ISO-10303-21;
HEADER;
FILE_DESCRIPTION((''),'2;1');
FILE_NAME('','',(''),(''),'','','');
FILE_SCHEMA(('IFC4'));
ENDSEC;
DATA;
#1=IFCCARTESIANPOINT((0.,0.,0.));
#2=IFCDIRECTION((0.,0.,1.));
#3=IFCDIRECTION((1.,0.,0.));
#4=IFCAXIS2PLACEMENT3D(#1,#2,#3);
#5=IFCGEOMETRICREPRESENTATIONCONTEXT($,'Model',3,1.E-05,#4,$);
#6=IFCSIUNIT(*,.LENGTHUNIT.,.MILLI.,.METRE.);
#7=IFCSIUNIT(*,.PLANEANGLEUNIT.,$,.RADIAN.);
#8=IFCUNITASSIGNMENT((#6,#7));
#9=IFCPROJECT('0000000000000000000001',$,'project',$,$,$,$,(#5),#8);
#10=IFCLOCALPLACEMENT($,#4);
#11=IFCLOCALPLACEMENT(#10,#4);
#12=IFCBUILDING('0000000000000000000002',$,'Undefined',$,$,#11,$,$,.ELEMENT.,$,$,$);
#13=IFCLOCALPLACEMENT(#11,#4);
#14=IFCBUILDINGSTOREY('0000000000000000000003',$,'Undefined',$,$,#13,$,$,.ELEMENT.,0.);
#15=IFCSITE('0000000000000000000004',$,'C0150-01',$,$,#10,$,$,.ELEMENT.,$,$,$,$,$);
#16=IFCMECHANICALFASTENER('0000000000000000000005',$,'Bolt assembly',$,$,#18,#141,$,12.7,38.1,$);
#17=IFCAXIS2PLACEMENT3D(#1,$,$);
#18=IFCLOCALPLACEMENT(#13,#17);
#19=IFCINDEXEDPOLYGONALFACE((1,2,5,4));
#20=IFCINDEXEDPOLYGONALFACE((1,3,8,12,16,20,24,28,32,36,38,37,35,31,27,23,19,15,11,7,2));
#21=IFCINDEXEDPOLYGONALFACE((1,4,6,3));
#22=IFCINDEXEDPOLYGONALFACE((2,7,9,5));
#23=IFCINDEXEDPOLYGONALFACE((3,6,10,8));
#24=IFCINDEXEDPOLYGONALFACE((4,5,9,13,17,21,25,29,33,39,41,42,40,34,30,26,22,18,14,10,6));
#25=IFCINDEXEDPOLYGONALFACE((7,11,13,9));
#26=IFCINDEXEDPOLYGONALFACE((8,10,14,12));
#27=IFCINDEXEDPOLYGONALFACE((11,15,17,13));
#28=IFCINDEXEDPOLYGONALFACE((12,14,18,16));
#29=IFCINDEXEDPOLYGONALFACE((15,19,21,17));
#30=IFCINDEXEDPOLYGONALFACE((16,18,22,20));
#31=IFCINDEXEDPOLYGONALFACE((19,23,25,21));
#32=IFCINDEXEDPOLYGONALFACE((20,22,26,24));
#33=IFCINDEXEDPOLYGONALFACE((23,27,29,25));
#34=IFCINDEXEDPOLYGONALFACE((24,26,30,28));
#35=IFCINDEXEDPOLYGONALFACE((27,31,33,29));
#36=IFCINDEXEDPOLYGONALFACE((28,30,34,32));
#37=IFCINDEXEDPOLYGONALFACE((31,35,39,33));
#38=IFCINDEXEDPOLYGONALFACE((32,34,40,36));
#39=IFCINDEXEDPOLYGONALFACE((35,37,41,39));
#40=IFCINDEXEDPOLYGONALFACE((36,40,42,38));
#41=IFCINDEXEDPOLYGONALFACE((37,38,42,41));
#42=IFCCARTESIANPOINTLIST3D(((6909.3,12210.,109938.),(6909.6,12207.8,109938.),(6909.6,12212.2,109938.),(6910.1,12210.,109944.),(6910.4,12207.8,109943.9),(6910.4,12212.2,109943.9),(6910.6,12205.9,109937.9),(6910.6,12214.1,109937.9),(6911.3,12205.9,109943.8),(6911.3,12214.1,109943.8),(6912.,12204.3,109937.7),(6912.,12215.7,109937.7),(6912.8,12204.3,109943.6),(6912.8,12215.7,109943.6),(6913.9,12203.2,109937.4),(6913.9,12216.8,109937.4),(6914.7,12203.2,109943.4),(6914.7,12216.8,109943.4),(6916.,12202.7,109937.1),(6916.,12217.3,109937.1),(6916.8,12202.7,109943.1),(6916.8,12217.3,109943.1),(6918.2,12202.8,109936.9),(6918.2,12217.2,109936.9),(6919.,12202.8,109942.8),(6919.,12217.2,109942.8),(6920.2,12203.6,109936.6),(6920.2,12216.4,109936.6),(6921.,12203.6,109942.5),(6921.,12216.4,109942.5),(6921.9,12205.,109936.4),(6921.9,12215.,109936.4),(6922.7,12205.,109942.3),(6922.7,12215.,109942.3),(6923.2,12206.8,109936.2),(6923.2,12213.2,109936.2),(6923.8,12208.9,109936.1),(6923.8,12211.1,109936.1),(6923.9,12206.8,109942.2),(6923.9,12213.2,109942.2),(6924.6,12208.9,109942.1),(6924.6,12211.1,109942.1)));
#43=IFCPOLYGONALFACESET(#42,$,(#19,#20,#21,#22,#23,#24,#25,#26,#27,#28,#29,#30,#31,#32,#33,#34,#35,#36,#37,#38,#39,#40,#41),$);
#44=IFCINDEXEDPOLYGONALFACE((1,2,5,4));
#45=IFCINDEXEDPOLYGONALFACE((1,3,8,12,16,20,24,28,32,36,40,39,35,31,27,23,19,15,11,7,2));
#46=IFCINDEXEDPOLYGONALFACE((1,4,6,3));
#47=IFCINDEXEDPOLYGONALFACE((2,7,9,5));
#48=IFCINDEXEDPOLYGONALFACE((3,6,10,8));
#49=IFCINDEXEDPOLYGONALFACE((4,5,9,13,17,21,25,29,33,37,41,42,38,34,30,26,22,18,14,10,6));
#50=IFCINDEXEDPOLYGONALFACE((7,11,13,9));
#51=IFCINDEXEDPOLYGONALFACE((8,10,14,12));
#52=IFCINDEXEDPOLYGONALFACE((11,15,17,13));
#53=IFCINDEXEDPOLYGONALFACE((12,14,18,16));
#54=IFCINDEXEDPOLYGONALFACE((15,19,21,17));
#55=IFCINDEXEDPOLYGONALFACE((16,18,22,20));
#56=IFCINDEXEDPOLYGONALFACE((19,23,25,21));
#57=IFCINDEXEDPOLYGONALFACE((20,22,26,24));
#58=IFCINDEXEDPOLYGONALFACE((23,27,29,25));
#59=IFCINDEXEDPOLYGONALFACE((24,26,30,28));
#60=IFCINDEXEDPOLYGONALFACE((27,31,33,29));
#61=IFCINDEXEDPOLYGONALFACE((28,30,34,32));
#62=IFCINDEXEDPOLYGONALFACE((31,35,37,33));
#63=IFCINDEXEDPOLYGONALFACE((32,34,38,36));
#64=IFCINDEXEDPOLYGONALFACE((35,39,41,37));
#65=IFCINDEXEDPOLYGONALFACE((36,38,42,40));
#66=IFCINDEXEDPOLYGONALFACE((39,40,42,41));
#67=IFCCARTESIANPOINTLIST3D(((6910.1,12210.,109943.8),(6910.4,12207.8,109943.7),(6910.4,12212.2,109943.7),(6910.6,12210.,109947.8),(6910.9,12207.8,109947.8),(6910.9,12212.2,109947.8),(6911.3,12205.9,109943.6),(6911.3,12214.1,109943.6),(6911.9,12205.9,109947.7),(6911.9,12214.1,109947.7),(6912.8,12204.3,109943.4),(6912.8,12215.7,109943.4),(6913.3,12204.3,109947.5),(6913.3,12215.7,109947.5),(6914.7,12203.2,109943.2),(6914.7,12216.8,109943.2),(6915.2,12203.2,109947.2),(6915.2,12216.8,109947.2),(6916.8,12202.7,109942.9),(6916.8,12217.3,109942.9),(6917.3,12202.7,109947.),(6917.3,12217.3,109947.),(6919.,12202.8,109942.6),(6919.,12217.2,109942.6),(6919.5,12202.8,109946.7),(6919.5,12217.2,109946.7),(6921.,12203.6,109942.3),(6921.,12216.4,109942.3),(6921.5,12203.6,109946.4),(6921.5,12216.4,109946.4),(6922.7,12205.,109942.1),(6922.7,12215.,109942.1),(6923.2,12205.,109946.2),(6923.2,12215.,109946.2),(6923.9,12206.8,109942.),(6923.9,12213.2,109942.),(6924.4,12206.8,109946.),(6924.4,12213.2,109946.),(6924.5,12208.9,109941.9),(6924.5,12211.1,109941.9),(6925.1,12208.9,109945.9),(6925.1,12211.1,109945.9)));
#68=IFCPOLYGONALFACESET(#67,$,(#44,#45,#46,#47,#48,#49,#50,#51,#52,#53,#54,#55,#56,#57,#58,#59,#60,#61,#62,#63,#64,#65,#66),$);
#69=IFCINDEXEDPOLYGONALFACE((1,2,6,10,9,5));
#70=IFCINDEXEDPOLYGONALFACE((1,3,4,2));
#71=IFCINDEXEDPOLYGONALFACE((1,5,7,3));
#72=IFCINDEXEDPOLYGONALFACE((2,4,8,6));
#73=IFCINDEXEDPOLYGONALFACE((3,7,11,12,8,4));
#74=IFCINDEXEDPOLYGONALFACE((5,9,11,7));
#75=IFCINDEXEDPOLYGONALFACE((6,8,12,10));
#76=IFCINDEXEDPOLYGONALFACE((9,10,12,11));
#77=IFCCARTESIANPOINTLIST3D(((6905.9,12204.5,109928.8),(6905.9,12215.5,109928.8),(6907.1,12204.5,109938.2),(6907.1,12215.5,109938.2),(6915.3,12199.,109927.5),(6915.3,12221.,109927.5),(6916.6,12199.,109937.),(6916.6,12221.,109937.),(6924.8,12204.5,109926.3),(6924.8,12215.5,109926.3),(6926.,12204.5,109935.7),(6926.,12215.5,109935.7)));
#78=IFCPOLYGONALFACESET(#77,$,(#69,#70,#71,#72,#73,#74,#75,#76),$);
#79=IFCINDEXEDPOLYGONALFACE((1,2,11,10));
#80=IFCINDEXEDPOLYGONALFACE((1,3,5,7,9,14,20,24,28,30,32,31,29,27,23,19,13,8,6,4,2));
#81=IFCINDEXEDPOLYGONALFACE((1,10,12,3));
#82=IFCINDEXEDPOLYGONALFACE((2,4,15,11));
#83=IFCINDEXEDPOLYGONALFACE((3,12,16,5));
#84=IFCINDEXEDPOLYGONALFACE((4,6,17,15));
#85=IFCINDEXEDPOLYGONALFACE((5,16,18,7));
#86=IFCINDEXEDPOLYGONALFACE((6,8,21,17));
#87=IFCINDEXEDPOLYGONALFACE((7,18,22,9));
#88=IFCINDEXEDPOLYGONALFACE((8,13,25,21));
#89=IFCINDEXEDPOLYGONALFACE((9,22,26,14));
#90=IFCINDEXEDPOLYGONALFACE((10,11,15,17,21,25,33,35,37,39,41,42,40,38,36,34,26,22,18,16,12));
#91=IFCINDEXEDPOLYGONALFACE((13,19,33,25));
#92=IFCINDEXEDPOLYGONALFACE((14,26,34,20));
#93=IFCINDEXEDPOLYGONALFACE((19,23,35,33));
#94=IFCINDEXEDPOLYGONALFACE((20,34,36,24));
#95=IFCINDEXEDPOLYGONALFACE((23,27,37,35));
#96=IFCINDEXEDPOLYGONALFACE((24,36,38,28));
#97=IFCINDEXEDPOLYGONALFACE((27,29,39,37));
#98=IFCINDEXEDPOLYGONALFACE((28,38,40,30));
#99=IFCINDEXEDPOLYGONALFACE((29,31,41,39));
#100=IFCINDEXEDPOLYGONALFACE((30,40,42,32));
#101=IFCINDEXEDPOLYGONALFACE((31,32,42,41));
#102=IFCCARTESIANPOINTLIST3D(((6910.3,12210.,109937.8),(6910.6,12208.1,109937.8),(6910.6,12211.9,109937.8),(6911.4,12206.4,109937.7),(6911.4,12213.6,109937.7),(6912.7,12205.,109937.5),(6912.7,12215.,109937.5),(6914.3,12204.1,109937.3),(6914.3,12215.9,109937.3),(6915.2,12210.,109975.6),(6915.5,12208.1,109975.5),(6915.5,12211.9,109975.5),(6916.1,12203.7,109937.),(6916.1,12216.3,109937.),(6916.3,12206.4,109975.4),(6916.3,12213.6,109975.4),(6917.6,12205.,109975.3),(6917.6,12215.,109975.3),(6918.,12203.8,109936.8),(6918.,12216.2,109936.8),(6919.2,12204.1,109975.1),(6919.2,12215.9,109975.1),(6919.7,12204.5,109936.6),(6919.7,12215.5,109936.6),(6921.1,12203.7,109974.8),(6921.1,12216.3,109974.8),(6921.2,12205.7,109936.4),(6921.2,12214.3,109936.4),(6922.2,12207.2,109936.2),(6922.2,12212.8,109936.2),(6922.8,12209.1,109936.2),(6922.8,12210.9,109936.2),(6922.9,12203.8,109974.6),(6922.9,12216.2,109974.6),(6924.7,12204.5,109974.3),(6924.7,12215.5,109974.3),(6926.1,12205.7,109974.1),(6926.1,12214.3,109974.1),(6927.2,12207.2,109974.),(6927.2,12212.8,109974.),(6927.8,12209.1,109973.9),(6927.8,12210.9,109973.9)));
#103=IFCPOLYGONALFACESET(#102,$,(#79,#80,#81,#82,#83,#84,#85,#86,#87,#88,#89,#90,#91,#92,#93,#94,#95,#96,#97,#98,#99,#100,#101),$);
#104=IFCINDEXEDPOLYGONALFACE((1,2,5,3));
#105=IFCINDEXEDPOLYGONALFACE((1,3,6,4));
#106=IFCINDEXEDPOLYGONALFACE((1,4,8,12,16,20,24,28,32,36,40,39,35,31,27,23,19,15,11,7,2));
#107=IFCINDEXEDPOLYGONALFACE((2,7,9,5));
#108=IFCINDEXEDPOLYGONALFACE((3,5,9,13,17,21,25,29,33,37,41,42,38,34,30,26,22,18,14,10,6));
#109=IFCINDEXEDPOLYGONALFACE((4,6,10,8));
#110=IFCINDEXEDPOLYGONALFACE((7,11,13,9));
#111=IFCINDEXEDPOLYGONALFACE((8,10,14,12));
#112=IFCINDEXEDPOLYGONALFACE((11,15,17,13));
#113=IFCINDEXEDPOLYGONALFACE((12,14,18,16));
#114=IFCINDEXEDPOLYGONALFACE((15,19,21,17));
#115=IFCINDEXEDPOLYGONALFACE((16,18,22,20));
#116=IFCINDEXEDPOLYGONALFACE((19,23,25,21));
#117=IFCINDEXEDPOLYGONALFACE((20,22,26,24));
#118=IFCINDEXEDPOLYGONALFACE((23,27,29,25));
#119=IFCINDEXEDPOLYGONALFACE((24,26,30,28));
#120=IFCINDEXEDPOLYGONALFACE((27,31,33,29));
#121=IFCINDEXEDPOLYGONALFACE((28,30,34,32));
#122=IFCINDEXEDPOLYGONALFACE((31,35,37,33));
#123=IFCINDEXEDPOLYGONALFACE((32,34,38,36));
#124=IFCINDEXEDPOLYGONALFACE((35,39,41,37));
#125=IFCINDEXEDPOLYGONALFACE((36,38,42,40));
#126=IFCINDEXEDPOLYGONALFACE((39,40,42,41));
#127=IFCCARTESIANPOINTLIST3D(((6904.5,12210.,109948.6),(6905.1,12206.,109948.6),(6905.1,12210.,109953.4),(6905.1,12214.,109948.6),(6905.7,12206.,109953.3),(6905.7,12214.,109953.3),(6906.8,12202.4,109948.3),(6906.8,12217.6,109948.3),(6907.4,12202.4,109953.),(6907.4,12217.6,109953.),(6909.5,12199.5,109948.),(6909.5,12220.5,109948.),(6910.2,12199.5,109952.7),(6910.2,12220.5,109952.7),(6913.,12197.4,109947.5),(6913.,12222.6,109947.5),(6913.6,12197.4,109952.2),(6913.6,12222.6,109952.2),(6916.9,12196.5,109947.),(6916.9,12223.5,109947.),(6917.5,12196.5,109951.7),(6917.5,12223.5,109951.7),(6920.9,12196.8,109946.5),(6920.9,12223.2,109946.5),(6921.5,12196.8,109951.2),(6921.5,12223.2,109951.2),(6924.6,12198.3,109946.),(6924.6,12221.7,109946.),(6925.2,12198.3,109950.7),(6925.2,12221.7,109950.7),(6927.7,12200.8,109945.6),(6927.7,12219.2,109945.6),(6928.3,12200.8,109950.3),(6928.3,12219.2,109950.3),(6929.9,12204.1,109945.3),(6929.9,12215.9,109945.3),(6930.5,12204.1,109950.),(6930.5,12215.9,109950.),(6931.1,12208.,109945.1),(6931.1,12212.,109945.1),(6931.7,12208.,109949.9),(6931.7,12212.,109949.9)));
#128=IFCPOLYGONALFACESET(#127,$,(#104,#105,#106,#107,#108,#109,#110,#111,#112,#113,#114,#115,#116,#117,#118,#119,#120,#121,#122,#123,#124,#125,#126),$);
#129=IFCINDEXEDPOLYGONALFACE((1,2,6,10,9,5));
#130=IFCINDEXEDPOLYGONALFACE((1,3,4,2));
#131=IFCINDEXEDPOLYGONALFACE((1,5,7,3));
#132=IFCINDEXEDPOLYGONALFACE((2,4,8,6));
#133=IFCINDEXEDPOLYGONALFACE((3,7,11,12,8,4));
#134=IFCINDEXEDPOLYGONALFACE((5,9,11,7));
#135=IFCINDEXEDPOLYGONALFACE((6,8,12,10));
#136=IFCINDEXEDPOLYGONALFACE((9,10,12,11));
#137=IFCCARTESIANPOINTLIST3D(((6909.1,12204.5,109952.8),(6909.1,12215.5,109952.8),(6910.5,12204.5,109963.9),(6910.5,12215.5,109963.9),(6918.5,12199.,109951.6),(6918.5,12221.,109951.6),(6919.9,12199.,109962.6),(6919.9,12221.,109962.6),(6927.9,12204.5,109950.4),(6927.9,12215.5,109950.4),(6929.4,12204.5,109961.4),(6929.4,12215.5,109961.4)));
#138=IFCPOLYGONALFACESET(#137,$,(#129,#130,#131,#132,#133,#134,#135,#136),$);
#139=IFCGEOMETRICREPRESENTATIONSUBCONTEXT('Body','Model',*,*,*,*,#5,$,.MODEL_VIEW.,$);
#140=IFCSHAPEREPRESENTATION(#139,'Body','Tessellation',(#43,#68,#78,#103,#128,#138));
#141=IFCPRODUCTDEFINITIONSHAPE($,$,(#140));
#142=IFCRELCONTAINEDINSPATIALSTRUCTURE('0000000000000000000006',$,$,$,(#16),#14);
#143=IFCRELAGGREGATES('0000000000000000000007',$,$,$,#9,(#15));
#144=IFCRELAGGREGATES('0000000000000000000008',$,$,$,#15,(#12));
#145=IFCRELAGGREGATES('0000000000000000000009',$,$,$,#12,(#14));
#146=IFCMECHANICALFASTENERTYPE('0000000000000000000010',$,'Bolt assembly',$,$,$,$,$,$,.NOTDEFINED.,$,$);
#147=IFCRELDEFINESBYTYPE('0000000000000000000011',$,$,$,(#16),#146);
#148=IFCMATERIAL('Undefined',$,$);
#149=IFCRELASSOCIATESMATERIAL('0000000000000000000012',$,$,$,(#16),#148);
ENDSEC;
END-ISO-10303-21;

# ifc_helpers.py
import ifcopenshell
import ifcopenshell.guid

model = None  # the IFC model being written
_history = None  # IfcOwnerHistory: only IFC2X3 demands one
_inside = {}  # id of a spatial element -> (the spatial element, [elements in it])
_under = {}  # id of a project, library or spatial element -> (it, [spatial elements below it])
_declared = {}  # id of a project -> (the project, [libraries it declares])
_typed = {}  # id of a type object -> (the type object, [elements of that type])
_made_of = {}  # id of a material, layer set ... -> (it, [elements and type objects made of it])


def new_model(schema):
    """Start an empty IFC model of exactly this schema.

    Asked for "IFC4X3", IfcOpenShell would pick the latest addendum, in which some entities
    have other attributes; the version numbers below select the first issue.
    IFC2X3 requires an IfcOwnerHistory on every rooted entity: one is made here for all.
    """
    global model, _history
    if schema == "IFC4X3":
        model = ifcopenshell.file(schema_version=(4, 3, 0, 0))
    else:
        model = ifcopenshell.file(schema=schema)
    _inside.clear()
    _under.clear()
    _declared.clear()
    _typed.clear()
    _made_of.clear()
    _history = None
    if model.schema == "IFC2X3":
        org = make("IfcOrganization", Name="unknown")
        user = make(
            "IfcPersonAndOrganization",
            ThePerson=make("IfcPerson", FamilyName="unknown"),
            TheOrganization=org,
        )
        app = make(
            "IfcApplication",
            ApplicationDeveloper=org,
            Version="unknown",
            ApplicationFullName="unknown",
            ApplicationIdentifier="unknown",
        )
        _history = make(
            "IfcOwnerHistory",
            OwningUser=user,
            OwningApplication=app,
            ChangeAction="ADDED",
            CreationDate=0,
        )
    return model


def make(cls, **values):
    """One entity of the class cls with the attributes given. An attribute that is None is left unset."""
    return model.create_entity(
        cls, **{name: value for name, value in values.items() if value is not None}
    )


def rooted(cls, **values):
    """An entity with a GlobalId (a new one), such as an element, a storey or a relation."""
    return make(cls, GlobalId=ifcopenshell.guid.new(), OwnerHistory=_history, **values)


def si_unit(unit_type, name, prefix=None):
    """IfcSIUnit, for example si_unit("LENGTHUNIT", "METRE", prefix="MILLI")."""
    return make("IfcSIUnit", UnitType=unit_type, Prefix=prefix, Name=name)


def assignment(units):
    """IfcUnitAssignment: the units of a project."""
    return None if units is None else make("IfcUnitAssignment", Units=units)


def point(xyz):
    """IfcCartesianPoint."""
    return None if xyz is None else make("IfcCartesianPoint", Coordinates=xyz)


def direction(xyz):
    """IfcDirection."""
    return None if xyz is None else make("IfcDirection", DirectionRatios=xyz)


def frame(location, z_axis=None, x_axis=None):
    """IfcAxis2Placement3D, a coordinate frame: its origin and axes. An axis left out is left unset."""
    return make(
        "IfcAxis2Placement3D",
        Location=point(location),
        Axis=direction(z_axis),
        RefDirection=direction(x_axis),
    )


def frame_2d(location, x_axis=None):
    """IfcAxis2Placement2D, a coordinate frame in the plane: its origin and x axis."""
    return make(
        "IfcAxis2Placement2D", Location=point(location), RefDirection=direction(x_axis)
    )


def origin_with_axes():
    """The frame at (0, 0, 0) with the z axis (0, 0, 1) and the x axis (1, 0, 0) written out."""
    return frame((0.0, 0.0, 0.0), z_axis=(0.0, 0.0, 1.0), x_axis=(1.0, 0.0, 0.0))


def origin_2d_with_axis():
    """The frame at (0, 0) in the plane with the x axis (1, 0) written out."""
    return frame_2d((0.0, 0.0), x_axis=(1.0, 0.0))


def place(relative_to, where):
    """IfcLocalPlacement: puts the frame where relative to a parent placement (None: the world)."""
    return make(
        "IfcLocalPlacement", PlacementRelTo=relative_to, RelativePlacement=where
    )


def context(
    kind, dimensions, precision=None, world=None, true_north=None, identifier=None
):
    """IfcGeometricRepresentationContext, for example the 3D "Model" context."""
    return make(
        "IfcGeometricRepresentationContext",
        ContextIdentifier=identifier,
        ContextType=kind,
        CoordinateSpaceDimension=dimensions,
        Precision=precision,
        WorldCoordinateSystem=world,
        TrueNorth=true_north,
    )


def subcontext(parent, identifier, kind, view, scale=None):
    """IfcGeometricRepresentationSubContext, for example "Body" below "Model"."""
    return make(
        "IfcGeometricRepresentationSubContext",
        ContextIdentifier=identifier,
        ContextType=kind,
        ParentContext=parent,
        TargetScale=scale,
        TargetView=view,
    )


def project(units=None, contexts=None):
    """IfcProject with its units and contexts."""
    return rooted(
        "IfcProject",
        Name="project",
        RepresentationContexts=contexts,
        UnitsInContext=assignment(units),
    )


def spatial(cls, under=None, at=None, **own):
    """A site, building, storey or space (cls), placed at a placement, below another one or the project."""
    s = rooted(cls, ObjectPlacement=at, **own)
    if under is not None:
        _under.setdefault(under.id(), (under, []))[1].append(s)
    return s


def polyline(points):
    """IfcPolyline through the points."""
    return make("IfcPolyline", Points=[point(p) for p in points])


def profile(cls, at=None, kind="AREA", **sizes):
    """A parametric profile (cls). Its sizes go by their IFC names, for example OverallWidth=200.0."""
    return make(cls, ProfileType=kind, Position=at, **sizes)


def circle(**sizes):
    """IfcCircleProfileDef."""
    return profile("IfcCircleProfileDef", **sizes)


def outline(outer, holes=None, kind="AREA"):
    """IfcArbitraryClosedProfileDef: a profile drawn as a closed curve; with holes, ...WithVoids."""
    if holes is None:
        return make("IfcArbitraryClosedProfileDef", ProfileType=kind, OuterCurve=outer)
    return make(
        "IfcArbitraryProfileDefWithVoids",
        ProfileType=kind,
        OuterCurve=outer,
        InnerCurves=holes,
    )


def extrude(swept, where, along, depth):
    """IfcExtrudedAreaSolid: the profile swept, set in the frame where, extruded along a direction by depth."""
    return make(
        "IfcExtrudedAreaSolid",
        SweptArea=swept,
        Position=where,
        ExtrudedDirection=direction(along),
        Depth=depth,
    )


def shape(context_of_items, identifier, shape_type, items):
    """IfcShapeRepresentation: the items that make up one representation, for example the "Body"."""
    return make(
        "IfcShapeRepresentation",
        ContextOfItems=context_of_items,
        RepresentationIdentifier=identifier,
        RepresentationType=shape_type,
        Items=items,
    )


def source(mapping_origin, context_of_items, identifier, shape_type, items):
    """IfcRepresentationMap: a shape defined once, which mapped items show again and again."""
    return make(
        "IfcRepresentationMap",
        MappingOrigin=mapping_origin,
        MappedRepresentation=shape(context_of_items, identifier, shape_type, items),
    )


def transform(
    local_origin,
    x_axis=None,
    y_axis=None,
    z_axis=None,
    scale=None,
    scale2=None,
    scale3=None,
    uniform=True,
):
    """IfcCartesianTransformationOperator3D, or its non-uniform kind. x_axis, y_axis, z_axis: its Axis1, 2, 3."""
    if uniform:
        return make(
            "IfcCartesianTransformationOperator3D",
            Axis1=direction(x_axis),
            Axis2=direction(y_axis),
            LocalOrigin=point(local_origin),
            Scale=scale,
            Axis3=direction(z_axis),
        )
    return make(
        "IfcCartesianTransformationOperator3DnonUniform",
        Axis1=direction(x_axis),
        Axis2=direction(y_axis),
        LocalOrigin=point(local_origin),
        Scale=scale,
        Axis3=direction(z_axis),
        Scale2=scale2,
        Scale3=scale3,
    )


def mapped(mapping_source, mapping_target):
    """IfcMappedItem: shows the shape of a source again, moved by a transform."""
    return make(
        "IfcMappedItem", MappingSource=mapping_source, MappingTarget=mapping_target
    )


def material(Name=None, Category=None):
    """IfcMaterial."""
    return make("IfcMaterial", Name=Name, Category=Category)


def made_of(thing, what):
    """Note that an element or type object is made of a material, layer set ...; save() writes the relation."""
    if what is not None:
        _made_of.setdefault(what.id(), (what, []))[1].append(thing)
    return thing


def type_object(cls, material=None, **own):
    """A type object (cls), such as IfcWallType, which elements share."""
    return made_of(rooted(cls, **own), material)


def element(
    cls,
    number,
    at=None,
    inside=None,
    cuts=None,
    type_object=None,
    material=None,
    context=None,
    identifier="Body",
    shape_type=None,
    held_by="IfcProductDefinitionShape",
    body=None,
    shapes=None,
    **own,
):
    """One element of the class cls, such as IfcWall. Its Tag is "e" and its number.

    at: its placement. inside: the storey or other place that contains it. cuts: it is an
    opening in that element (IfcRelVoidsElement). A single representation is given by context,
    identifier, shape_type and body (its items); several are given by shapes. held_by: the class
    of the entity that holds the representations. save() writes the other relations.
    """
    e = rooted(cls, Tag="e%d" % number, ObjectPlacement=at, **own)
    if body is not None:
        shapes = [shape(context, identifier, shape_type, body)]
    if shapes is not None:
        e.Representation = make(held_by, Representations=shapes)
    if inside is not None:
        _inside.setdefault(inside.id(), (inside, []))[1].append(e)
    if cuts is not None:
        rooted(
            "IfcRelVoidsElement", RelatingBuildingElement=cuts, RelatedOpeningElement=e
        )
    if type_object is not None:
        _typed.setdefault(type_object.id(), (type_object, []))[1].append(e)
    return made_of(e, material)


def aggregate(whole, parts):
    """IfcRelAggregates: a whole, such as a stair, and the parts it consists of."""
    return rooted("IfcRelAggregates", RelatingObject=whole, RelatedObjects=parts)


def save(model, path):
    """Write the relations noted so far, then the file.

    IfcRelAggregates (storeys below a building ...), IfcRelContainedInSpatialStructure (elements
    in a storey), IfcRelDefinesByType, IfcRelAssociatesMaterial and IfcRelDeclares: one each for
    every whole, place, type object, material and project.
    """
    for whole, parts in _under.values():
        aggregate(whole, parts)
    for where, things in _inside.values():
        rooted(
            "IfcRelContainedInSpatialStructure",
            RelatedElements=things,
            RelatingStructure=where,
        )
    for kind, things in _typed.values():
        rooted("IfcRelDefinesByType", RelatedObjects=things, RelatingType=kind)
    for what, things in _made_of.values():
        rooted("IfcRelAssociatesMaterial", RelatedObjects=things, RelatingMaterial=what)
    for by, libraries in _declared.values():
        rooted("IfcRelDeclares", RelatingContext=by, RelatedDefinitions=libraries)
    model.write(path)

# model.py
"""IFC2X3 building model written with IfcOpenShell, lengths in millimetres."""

from ifc_helpers import new_model, si_unit, frame, origin_with_axes, origin_2d_with_axis, place, context, subcontext, project, spatial, polyline, circle, outline, extrude, source, transform, mapped, material, type_object, element, save


model = new_model("IFC2X3")

# Units and contexts
model_context = context("Model", 3, precision=1e-05, world=origin_with_axes())
body_context = subcontext(model_context, "Body", "Model", "MODEL_VIEW")
ifc_project = project(units=[si_unit("LENGTHUNIT", "METRE", prefix="MILLI"), si_unit("PLANEANGLEUNIT", "RADIAN")], contexts=[model_context])

# Site, building, storey
site_placement = place(None, origin_with_axes())
site = spatial("IfcSite", under=ifc_project, at=site_placement, Name="C0150-01", CompositionType="ELEMENT")
building_placement = place(site_placement, origin_with_axes())
building = spatial("IfcBuilding", under=site, at=building_placement, Name="Undefined", CompositionType="ELEMENT")
storey_placement = place(building_placement, origin_with_axes())
storey = spatial("IfcBuildingStorey", under=building, at=storey_placement, Name="Undefined", CompositionType="ELEMENT", Elevation=0.0)

# Mechanical fastener
ifc_material_1 = material(Name="Undefined")
mechanical_fastener_type = type_object("IfcMechanicalFastenerType", Name="Bolt assembly")
shared_shape_1 = source(origin_with_axes(), body_context, "Body", "SweptSolid", [
    extrude(circle(Radius=7.3, at=origin_2d_with_axis()), frame((0.0, -9.9, 0.0), z_axis=(0.0, 1.0, 0.0), x_axis=(1.0, 0.0, 0.0)), (0.0, 0.0, 1.0), 6.0),
    extrude(circle(Radius=7.3, at=origin_2d_with_axis()), frame((0.0, -4.1, 0.0), z_axis=(0.0, 1.0, 0.0), x_axis=(1.0, 0.0, 0.0)), (0.0, 0.0, 1.0), 4.1),
    extrude(outline(polyline([(9.5, -5.5), (9.5, 5.5), (0.0, 11.0), (-9.5, 5.5), (-9.5, -5.5), (0.0, -11.0), (9.5, -5.5)])), frame((0.0, -19.5, 0.0), z_axis=(0.0, 1.0, 0.0), x_axis=(1.0, 0.0, 0.0)), (0.0, 0.0, 1.0), 9.5),
    extrude(circle(Radius=6.3, at=origin_2d_with_axis()), frame((0.0, -10.0, 0.0), z_axis=(0.0, 1.0, 0.0), x_axis=(1.0, 0.0, 0.0)), (0.0, 0.0, 1.0), 38.1),
    extrude(circle(Radius=13.5, at=origin_2d_with_axis()), frame((0.0, 0.0, 0.0), z_axis=(0.0, 1.0, 0.0), x_axis=(1.0, 0.0, 0.0)), (0.0, 0.0, 1.0), 4.8),
    extrude(outline(polyline([(9.5, -5.5), (9.5, 5.5), (0.0, 11.0), (-9.5, 5.5), (-9.5, -5.5), (0.0, -11.0), (9.5, -5.5)])), frame((0.0, 4.8, 0.0), z_axis=(0.0, 1.0, 0.0), x_axis=(1.0, 0.0, 0.0)), (0.0, 0.0, 1.0), 11.1),
])
for number, where, z_axis, x_axis, name in (
    (1, (6917.9, 12210.0, 109946.9), (0.0, 1.0, 0.0), (-0.991507, 0.0, 0.130054), "Bolt assembly"),
):
    element("IfcMechanicalFastener", number, at=place(storey_placement, frame(where, z_axis=z_axis, x_axis=x_axis)), inside=storey, type_object=mechanical_fastener_type, material=ifc_material_1, Name=name, NominalDiameter=12.7, NominalLength=38.1, context=body_context, shape_type="MappedRepresentation", body=[
        mapped(shared_shape_1, transform((0.0, 0.0, 0.0))),
    ])

save(model, "model.ifc")
